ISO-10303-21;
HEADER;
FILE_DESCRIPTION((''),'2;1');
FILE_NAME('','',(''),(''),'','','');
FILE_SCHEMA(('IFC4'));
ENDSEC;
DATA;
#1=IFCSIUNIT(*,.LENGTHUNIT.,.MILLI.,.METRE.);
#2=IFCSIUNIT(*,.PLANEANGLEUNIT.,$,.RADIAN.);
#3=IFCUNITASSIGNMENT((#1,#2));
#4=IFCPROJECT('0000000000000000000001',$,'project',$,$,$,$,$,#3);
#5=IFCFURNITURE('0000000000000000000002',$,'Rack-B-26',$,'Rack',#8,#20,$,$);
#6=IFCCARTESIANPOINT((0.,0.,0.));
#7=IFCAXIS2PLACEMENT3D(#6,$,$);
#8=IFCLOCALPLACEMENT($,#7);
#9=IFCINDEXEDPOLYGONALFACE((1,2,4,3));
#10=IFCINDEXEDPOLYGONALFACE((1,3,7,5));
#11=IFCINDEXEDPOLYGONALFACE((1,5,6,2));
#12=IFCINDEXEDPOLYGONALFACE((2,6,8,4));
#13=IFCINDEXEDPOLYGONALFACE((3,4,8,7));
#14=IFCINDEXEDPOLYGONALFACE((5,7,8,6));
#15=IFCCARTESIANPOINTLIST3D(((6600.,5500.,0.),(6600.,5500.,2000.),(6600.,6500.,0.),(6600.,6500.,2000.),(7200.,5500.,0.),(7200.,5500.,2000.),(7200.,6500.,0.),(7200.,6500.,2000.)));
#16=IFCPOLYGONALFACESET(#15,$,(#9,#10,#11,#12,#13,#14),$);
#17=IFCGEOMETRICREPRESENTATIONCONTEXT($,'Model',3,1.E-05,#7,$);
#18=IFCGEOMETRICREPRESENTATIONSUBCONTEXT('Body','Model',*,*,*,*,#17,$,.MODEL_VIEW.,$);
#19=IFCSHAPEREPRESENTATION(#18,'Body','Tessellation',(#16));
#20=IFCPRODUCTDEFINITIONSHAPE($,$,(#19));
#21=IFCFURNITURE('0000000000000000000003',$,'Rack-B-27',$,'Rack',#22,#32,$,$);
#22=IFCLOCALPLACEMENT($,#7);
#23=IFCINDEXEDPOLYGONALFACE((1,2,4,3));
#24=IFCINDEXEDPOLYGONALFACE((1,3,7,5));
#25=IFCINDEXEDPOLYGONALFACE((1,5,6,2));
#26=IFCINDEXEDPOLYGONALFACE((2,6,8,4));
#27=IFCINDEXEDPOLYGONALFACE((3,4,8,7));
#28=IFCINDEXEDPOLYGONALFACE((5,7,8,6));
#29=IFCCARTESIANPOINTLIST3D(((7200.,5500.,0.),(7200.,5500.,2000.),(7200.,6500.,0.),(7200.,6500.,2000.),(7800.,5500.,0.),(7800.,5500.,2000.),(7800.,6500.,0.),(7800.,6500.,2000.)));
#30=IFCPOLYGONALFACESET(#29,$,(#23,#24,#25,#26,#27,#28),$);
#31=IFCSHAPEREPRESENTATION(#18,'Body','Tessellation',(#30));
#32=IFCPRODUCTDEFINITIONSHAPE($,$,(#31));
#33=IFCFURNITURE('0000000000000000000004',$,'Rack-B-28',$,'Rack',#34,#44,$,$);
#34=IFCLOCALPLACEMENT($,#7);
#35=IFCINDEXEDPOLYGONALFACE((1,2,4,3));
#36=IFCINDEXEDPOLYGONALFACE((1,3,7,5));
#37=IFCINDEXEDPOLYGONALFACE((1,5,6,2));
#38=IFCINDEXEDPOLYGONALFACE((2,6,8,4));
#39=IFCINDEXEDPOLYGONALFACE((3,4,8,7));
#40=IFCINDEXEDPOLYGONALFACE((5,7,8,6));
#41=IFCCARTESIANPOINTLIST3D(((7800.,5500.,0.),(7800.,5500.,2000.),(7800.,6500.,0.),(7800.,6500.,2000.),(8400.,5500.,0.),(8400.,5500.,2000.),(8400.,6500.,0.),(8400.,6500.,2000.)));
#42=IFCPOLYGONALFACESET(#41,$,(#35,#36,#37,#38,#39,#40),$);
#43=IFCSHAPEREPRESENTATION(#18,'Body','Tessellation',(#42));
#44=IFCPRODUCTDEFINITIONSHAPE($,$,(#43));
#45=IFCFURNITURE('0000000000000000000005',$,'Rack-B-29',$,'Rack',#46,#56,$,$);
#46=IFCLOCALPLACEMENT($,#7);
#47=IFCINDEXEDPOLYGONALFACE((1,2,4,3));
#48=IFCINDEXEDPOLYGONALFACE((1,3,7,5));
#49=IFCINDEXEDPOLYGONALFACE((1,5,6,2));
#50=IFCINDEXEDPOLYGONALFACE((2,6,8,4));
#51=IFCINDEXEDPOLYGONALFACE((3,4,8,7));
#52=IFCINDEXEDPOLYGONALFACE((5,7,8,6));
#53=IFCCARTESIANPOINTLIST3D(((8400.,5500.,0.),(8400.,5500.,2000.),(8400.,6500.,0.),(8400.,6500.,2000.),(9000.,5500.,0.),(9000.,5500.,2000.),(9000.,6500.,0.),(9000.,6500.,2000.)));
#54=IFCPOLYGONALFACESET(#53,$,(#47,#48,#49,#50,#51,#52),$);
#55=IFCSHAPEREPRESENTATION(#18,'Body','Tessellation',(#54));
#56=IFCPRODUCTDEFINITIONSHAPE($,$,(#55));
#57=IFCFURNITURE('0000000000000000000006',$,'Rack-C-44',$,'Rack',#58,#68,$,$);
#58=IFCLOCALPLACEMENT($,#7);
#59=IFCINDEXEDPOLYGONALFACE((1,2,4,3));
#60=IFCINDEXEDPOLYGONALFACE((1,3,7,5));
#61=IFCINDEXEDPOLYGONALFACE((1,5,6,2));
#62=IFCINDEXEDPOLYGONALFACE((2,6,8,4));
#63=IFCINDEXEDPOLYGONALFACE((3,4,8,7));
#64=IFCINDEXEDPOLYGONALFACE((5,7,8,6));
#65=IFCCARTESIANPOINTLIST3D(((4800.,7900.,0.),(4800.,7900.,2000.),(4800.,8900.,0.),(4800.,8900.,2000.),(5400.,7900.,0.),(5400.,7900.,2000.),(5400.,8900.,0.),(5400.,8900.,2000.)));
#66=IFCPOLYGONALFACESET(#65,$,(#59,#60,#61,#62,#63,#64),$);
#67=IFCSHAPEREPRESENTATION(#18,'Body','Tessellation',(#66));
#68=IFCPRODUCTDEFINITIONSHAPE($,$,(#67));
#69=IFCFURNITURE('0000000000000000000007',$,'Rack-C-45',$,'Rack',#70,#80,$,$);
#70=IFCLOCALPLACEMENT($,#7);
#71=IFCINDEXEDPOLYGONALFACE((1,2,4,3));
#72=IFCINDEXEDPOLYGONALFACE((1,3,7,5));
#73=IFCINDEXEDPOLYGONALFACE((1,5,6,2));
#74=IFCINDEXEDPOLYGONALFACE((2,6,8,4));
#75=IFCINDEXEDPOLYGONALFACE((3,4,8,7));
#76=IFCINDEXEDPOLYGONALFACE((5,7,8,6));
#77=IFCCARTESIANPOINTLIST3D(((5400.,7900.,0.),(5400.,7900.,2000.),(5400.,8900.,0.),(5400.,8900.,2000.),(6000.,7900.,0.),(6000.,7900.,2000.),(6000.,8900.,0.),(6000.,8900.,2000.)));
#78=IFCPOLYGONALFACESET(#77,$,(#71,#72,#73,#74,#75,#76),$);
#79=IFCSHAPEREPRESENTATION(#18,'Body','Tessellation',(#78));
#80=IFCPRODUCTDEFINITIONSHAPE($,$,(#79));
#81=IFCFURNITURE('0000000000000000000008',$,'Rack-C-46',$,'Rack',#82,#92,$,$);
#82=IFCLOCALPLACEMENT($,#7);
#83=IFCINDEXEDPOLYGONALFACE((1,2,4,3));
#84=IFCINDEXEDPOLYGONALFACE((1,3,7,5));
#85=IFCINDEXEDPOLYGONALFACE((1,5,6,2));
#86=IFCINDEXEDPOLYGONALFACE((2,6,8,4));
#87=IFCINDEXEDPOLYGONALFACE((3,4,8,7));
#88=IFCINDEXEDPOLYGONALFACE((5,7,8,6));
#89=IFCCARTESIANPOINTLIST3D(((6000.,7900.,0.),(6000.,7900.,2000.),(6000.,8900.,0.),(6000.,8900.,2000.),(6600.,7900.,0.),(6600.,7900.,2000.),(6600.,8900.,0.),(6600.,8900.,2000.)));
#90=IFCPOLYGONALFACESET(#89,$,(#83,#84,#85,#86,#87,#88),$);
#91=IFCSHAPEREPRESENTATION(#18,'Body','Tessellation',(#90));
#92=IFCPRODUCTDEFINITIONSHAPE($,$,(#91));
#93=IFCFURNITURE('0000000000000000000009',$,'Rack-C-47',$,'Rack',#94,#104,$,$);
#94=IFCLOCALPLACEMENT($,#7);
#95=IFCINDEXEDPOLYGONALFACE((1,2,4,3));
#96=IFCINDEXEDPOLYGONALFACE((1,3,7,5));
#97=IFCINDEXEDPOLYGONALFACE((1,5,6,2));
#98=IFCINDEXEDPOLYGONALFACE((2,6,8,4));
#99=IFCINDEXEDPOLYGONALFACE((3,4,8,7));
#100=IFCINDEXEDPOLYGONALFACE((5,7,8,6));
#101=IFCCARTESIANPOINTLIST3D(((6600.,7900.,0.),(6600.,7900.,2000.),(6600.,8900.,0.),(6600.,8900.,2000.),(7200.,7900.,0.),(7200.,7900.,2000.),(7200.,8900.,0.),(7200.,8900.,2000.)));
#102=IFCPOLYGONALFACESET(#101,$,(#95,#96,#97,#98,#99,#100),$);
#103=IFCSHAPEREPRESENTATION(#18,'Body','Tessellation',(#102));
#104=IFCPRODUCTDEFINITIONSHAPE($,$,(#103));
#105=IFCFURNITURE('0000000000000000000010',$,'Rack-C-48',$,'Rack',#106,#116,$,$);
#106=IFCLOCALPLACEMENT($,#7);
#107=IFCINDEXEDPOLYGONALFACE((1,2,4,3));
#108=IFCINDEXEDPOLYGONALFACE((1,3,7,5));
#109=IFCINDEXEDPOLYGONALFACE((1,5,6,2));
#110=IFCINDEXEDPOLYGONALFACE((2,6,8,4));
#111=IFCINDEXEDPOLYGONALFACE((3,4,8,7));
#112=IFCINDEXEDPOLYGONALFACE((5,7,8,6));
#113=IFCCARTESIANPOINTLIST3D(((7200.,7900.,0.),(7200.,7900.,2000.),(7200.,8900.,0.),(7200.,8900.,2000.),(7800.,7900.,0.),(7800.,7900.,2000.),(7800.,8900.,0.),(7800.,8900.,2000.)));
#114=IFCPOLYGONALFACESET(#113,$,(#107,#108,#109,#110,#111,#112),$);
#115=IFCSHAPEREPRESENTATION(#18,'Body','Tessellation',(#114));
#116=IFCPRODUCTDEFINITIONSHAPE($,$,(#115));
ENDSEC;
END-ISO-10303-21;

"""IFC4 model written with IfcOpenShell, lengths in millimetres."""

from ifc_helpers import new_model, si_unit, frame, origin, place, context, subcontext, project, rectangle, extrude, element, save


model = new_model("IFC4")

# Units and contexts
model_context = context("Model", 3, precision=1e-05, world=origin())
body_context = subcontext(model_context, "Body", "Model", "MODEL_VIEW")
ifc_project = project(units=[si_unit("LENGTHUNIT", "METRE", prefix="MILLI"), si_unit("PLANEANGLEUNIT", "RADIAN")])

# Furniture
for number, where, name in (
    (1, (6900.0, 6000.0, 0.0), "Rack-B-26"),
    (2, (7500.0, 6000.0, 0.0), "Rack-B-27"),
    (3, (8100.0, 6000.0, 0.0), "Rack-B-28"),
    (4, (8700.0, 6000.0, 0.0), "Rack-B-29"),
    (5, (5100.0, 8400.0, 0.0), "Rack-C-44"),
    (6, (5700.0, 8400.0, 0.0), "Rack-C-45"),
    (7, (6300.0, 8400.0, 0.0), "Rack-C-46"),
    (8, (6900.0, 8400.0, 0.0), "Rack-C-47"),
    (9, (7500.0, 8400.0, 0.0), "Rack-C-48"),
):
    element("IfcFurniture", number, at=place(None, frame(where)), Name=name, ObjectType="Rack", context=body_context, shape_type="SweptSolid", body=[
        extrude(rectangle(XDim=600.0, YDim=1000.0), None, (0.0, 0.0, 1.0), 2000.0),
    ])

save(model, "model.ifc")
